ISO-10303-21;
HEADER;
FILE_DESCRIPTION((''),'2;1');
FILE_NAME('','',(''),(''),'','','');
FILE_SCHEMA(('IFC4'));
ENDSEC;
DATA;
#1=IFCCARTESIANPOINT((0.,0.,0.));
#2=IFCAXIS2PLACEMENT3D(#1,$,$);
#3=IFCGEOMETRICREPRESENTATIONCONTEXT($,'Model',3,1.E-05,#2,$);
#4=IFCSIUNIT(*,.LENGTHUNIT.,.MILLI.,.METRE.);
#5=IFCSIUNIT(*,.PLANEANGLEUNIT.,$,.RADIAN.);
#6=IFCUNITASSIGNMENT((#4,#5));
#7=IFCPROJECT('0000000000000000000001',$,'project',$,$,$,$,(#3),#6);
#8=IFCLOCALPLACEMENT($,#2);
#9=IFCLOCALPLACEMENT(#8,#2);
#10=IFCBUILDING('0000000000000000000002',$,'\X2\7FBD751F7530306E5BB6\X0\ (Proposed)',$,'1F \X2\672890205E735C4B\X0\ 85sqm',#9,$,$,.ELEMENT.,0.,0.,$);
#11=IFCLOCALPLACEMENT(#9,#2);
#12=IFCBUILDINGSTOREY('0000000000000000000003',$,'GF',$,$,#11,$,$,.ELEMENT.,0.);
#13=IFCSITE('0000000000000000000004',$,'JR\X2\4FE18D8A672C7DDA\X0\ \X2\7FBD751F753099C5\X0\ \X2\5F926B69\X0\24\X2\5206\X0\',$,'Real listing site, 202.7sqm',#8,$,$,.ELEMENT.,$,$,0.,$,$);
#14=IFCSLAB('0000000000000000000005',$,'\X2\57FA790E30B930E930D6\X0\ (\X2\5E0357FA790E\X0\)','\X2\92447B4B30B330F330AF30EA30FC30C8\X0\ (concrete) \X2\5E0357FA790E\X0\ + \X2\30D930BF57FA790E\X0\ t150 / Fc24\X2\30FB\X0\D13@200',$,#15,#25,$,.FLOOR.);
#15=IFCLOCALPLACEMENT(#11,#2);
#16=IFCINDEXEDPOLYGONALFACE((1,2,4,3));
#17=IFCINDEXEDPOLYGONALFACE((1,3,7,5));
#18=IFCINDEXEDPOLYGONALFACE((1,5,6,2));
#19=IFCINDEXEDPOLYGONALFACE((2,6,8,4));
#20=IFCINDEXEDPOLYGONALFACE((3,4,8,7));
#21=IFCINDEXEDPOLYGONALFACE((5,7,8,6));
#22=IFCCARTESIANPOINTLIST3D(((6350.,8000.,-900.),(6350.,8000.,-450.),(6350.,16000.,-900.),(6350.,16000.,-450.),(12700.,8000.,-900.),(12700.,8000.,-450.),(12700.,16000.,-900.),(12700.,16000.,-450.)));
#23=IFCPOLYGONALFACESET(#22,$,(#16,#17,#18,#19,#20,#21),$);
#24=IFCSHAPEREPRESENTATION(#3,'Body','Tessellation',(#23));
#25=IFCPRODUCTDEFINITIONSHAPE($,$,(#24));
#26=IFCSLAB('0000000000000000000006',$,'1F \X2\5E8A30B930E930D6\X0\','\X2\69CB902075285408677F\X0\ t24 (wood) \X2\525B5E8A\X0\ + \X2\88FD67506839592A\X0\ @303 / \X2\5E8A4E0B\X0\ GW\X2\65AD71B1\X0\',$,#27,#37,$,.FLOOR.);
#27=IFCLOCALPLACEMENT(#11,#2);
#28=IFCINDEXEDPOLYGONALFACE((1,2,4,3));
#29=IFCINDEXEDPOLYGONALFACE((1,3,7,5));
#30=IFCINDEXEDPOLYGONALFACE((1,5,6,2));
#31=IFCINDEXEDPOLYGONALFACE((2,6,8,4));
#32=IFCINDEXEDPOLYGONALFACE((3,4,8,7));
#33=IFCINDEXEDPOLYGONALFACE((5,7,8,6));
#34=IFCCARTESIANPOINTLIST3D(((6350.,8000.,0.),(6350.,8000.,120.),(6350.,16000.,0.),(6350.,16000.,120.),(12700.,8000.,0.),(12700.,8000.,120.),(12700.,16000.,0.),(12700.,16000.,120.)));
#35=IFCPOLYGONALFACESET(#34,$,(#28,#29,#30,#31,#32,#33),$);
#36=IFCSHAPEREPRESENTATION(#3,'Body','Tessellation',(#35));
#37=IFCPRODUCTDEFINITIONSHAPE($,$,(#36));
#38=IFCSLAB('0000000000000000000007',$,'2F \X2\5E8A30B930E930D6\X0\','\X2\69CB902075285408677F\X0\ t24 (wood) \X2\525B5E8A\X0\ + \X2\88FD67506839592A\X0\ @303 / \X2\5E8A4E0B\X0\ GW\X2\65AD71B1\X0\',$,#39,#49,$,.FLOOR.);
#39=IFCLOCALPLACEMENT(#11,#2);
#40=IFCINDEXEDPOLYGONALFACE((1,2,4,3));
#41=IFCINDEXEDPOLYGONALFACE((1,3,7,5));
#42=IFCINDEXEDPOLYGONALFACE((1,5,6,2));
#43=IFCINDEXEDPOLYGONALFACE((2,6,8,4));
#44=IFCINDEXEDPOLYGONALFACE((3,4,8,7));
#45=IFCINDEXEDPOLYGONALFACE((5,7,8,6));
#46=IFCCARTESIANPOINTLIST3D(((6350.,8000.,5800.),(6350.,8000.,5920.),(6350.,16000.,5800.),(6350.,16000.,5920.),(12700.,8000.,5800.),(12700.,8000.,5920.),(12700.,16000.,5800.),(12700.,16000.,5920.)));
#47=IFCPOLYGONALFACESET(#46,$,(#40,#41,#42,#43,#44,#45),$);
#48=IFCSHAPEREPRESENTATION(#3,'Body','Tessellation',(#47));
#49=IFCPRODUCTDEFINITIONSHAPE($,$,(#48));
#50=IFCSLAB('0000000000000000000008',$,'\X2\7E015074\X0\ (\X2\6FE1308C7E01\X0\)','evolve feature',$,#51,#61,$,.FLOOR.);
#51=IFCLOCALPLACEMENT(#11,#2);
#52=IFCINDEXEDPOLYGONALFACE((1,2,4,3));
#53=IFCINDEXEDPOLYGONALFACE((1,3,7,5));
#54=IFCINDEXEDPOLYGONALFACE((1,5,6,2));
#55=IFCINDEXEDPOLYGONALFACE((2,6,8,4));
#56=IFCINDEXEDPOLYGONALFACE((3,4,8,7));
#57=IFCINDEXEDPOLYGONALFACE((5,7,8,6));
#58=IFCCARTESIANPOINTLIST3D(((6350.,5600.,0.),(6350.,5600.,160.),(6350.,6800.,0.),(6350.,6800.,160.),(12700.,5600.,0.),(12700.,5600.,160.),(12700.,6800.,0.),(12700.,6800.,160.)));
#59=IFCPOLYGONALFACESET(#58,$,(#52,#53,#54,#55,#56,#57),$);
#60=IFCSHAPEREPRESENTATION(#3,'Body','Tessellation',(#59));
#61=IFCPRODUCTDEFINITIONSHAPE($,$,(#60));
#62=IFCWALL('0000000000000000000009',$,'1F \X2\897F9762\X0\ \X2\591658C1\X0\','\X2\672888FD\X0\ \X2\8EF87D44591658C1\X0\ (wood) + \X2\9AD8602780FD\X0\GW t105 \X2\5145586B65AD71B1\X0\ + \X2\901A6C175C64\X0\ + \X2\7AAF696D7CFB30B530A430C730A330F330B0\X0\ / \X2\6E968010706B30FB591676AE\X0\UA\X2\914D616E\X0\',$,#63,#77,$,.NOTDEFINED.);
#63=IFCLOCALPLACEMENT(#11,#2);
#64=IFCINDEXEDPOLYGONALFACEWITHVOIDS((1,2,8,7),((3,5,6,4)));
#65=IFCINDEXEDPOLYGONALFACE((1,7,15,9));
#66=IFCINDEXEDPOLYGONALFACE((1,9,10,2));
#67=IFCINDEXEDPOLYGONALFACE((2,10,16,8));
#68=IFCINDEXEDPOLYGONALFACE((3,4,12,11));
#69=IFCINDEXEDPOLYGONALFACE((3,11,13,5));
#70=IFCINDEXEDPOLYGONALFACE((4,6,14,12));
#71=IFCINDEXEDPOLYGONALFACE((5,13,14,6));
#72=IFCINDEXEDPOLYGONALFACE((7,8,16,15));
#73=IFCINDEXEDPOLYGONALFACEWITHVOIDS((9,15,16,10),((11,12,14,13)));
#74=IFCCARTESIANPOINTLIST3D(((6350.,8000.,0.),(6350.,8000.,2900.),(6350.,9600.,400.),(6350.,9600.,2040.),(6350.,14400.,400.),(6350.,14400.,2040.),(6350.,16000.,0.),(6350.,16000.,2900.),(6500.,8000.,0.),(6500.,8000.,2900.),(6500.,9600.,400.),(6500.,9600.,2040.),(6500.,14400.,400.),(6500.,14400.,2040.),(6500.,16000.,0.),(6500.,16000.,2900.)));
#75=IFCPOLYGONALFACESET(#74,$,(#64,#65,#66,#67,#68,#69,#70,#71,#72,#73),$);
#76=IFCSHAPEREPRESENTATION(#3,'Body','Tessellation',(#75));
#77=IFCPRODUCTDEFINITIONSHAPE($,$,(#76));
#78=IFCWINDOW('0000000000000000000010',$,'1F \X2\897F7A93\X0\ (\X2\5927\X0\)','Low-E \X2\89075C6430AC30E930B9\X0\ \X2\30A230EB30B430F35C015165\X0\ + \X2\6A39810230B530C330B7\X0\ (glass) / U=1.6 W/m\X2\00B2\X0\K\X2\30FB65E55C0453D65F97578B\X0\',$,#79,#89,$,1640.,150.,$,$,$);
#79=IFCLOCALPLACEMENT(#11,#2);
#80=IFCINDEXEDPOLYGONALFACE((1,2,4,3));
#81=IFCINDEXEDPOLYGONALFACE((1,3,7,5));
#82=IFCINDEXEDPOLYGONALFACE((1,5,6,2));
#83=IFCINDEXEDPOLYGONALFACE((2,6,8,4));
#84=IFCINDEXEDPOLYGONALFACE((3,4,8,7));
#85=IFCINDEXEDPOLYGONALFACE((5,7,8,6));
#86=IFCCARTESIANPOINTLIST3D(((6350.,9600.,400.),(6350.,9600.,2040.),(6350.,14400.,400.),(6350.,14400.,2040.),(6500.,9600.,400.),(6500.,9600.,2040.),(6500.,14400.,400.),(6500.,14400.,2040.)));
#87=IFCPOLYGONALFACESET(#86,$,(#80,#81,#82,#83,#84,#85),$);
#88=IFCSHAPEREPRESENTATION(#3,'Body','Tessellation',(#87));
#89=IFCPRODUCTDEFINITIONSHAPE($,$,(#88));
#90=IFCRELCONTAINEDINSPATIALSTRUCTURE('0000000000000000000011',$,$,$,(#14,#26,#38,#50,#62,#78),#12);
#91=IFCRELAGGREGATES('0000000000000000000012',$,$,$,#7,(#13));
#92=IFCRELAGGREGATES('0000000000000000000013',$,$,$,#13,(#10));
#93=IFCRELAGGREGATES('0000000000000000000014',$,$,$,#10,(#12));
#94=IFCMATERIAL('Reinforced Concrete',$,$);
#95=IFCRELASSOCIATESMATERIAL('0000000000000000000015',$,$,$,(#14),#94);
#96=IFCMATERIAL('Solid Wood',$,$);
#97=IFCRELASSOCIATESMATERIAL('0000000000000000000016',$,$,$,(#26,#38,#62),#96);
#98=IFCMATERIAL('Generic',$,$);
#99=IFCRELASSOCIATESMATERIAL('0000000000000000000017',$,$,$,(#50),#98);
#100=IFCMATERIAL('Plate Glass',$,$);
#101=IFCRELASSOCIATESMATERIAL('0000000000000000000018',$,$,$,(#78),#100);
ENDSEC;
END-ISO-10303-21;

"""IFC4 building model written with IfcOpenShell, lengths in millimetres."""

from ifc_helpers import new_model, si_unit, frame, frame_2d, origin, place, context, project, spatial, rectangle, extrude, material, element, fill, save


model = new_model("IFC4")

# Units and contexts
model_context = context("Model", 3, precision=1e-05, world=origin())
ifc_project = project(units=[si_unit("LENGTHUNIT", "METRE", prefix="MILLI"), si_unit("PLANEANGLEUNIT", "RADIAN")], contexts=[model_context])

# Site, building, storey
site_placement = place(None, origin())
site = spatial("IfcSite", under=ifc_project, at=site_placement, Name="JR信越本線 羽生田駅 徒歩24分", ObjectType="Real listing site, 202.7sqm", CompositionType="ELEMENT", RefElevation=0.0)
building_placement = place(site_placement, origin())
building = spatial("IfcBuilding", under=site, at=building_placement, Name="羽生田の家 (Proposed)", ObjectType="1F 木造平屋 85sqm", CompositionType="ELEMENT", ElevationOfRefHeight=0.0, ElevationOfTerrain=0.0)
storey_placement = place(building_placement, origin())
storey = spatial("IfcBuildingStorey", under=building, at=storey_placement, Name="GF", CompositionType="ELEMENT", Elevation=0.0)

# Slabs
ifc_material_1 = material(Name="Reinforced Concrete")
slab_1_placement = place(storey_placement, frame((3175.0, 4000.0, -450.0)))
element("IfcSlab", 1, at=slab_1_placement, inside=storey, material=ifc_material_1, Name="基礎スラブ (布基礎)", Description="鉄筋コンクリート (concrete) 布基礎 + ベタ基礎 t150 / Fc24・D13@200", PredefinedType="FLOOR", context=model_context, shape_type="SweptSolid", body=[
    extrude(rectangle(XDim=6350.0, YDim=8000.0, at=frame_2d((3175.0, 4000.0))), frame((3175.0, 4000.0, -450.0)), (0.0, 0.0, 1.0), 450.0),
])
ifc_material_2 = material(Name="Solid Wood")
slab_2_placement = place(storey_placement, frame((3175.0, 4000.0, 0.0)))
element("IfcSlab", 2, at=slab_2_placement, inside=storey, material=ifc_material_2, Name="1F 床スラブ", Description="構造用合板 t24 (wood) 剛床 + 製材根太 @303 / 床下 GW断熱", PredefinedType="FLOOR", context=model_context, shape_type="SweptSolid", body=[
    extrude(rectangle(XDim=6350.0, YDim=8000.0, at=frame_2d((3175.0, 4000.0))), frame((3175.0, 4000.0, 0.0)), (0.0, 0.0, 1.0), 120.0),
])
slab_3_placement = place(storey_placement, frame((3175.0, 4000.0, 2900.0)))
element("IfcSlab", 3, at=slab_3_placement, inside=storey, material=ifc_material_2, Name="2F 床スラブ", Description="構造用合板 t24 (wood) 剛床 + 製材根太 @303 / 床下 GW断熱", PredefinedType="FLOOR", context=model_context, shape_type="SweptSolid", body=[
    extrude(rectangle(XDim=6350.0, YDim=8000.0, at=frame_2d((3175.0, 4000.0))), frame((3175.0, 4000.0, 2900.0)), (0.0, 0.0, 1.0), 120.0),
])
ifc_material_3 = material(Name="Generic")
slab_4_placement = place(storey_placement, frame((3175.0, 2800.0, 0.0)))
element("IfcSlab", 4, at=slab_4_placement, inside=storey, material=ifc_material_3, Name="縁側 (濡れ縁)", Description="evolve feature", PredefinedType="FLOOR", context=model_context, shape_type="SweptSolid", body=[
    extrude(rectangle(XDim=6350.0, YDim=1200.0, at=frame_2d((3175.0, 600.0))), frame((3175.0, 2800.0, 0.0)), (0.0, 0.0, 1.0), 160.0),
])

# Shared definitions
ifc_material_4 = material(Name="Plate Glass")

# Wall, opening, window
wall_1_placement = place(storey_placement, frame((3175.0, 4000.0, 0.0)))
wall_1 = element("IfcWall", 5, at=wall_1_placement, inside=storey, material=ifc_material_2, Name="1F 西面 外壁", Description="木製 軸組外壁 (wood) + 高性能GW t105 充填断熱 + 通気層 + 窯業系サイディング / 準耐火・外皮UA配慮", PredefinedType="NOTDEFINED", context=model_context, shape_type="SweptSolid", body=[
    extrude(rectangle(XDim=150.0, YDim=8000.0, at=frame_2d((75.0, 4000.0))), frame((3175.0, 4000.0, 0.0)), (0.0, 0.0, 1.0), 2900.0),
])
opening_1_placement = place(storey_placement, frame((3175.0, 4800.0, 200.0)))
opening_1 = element("IfcOpeningElement", 6, at=opening_1_placement, cuts=wall_1, PredefinedType="NOTDEFINED", context=model_context, shape_type="SweptSolid", body=[
    extrude(rectangle(XDim=150.0, YDim=4800.0, at=frame_2d((75.0, 2400.0))), frame((3175.0, 4800.0, 200.0)), (0.0, 0.0, 1.0), 1640.0),
])
window_1_placement = place(storey_placement, frame((3175.0, 4800.0, 200.0)))
window_1 = element("IfcWindow", 7, at=window_1_placement, inside=storey, material=ifc_material_4, Name="1F 西窓 (大)", Description="Low-E 複層ガラス アルゴン封入 + 樹脂サッシ (glass) / U=1.6 W/m²K・日射取得型", OverallHeight=1640.0, OverallWidth=150.0, context=model_context, shape_type="SweptSolid", body=[
    extrude(rectangle(XDim=150.0, YDim=4800.0, at=frame_2d((75.0, 2400.0))), frame((3175.0, 4800.0, 200.0)), (0.0, 0.0, 1.0), 1640.0),
])
fill(opening_1, window_1)

save(model, "model.ifc")
